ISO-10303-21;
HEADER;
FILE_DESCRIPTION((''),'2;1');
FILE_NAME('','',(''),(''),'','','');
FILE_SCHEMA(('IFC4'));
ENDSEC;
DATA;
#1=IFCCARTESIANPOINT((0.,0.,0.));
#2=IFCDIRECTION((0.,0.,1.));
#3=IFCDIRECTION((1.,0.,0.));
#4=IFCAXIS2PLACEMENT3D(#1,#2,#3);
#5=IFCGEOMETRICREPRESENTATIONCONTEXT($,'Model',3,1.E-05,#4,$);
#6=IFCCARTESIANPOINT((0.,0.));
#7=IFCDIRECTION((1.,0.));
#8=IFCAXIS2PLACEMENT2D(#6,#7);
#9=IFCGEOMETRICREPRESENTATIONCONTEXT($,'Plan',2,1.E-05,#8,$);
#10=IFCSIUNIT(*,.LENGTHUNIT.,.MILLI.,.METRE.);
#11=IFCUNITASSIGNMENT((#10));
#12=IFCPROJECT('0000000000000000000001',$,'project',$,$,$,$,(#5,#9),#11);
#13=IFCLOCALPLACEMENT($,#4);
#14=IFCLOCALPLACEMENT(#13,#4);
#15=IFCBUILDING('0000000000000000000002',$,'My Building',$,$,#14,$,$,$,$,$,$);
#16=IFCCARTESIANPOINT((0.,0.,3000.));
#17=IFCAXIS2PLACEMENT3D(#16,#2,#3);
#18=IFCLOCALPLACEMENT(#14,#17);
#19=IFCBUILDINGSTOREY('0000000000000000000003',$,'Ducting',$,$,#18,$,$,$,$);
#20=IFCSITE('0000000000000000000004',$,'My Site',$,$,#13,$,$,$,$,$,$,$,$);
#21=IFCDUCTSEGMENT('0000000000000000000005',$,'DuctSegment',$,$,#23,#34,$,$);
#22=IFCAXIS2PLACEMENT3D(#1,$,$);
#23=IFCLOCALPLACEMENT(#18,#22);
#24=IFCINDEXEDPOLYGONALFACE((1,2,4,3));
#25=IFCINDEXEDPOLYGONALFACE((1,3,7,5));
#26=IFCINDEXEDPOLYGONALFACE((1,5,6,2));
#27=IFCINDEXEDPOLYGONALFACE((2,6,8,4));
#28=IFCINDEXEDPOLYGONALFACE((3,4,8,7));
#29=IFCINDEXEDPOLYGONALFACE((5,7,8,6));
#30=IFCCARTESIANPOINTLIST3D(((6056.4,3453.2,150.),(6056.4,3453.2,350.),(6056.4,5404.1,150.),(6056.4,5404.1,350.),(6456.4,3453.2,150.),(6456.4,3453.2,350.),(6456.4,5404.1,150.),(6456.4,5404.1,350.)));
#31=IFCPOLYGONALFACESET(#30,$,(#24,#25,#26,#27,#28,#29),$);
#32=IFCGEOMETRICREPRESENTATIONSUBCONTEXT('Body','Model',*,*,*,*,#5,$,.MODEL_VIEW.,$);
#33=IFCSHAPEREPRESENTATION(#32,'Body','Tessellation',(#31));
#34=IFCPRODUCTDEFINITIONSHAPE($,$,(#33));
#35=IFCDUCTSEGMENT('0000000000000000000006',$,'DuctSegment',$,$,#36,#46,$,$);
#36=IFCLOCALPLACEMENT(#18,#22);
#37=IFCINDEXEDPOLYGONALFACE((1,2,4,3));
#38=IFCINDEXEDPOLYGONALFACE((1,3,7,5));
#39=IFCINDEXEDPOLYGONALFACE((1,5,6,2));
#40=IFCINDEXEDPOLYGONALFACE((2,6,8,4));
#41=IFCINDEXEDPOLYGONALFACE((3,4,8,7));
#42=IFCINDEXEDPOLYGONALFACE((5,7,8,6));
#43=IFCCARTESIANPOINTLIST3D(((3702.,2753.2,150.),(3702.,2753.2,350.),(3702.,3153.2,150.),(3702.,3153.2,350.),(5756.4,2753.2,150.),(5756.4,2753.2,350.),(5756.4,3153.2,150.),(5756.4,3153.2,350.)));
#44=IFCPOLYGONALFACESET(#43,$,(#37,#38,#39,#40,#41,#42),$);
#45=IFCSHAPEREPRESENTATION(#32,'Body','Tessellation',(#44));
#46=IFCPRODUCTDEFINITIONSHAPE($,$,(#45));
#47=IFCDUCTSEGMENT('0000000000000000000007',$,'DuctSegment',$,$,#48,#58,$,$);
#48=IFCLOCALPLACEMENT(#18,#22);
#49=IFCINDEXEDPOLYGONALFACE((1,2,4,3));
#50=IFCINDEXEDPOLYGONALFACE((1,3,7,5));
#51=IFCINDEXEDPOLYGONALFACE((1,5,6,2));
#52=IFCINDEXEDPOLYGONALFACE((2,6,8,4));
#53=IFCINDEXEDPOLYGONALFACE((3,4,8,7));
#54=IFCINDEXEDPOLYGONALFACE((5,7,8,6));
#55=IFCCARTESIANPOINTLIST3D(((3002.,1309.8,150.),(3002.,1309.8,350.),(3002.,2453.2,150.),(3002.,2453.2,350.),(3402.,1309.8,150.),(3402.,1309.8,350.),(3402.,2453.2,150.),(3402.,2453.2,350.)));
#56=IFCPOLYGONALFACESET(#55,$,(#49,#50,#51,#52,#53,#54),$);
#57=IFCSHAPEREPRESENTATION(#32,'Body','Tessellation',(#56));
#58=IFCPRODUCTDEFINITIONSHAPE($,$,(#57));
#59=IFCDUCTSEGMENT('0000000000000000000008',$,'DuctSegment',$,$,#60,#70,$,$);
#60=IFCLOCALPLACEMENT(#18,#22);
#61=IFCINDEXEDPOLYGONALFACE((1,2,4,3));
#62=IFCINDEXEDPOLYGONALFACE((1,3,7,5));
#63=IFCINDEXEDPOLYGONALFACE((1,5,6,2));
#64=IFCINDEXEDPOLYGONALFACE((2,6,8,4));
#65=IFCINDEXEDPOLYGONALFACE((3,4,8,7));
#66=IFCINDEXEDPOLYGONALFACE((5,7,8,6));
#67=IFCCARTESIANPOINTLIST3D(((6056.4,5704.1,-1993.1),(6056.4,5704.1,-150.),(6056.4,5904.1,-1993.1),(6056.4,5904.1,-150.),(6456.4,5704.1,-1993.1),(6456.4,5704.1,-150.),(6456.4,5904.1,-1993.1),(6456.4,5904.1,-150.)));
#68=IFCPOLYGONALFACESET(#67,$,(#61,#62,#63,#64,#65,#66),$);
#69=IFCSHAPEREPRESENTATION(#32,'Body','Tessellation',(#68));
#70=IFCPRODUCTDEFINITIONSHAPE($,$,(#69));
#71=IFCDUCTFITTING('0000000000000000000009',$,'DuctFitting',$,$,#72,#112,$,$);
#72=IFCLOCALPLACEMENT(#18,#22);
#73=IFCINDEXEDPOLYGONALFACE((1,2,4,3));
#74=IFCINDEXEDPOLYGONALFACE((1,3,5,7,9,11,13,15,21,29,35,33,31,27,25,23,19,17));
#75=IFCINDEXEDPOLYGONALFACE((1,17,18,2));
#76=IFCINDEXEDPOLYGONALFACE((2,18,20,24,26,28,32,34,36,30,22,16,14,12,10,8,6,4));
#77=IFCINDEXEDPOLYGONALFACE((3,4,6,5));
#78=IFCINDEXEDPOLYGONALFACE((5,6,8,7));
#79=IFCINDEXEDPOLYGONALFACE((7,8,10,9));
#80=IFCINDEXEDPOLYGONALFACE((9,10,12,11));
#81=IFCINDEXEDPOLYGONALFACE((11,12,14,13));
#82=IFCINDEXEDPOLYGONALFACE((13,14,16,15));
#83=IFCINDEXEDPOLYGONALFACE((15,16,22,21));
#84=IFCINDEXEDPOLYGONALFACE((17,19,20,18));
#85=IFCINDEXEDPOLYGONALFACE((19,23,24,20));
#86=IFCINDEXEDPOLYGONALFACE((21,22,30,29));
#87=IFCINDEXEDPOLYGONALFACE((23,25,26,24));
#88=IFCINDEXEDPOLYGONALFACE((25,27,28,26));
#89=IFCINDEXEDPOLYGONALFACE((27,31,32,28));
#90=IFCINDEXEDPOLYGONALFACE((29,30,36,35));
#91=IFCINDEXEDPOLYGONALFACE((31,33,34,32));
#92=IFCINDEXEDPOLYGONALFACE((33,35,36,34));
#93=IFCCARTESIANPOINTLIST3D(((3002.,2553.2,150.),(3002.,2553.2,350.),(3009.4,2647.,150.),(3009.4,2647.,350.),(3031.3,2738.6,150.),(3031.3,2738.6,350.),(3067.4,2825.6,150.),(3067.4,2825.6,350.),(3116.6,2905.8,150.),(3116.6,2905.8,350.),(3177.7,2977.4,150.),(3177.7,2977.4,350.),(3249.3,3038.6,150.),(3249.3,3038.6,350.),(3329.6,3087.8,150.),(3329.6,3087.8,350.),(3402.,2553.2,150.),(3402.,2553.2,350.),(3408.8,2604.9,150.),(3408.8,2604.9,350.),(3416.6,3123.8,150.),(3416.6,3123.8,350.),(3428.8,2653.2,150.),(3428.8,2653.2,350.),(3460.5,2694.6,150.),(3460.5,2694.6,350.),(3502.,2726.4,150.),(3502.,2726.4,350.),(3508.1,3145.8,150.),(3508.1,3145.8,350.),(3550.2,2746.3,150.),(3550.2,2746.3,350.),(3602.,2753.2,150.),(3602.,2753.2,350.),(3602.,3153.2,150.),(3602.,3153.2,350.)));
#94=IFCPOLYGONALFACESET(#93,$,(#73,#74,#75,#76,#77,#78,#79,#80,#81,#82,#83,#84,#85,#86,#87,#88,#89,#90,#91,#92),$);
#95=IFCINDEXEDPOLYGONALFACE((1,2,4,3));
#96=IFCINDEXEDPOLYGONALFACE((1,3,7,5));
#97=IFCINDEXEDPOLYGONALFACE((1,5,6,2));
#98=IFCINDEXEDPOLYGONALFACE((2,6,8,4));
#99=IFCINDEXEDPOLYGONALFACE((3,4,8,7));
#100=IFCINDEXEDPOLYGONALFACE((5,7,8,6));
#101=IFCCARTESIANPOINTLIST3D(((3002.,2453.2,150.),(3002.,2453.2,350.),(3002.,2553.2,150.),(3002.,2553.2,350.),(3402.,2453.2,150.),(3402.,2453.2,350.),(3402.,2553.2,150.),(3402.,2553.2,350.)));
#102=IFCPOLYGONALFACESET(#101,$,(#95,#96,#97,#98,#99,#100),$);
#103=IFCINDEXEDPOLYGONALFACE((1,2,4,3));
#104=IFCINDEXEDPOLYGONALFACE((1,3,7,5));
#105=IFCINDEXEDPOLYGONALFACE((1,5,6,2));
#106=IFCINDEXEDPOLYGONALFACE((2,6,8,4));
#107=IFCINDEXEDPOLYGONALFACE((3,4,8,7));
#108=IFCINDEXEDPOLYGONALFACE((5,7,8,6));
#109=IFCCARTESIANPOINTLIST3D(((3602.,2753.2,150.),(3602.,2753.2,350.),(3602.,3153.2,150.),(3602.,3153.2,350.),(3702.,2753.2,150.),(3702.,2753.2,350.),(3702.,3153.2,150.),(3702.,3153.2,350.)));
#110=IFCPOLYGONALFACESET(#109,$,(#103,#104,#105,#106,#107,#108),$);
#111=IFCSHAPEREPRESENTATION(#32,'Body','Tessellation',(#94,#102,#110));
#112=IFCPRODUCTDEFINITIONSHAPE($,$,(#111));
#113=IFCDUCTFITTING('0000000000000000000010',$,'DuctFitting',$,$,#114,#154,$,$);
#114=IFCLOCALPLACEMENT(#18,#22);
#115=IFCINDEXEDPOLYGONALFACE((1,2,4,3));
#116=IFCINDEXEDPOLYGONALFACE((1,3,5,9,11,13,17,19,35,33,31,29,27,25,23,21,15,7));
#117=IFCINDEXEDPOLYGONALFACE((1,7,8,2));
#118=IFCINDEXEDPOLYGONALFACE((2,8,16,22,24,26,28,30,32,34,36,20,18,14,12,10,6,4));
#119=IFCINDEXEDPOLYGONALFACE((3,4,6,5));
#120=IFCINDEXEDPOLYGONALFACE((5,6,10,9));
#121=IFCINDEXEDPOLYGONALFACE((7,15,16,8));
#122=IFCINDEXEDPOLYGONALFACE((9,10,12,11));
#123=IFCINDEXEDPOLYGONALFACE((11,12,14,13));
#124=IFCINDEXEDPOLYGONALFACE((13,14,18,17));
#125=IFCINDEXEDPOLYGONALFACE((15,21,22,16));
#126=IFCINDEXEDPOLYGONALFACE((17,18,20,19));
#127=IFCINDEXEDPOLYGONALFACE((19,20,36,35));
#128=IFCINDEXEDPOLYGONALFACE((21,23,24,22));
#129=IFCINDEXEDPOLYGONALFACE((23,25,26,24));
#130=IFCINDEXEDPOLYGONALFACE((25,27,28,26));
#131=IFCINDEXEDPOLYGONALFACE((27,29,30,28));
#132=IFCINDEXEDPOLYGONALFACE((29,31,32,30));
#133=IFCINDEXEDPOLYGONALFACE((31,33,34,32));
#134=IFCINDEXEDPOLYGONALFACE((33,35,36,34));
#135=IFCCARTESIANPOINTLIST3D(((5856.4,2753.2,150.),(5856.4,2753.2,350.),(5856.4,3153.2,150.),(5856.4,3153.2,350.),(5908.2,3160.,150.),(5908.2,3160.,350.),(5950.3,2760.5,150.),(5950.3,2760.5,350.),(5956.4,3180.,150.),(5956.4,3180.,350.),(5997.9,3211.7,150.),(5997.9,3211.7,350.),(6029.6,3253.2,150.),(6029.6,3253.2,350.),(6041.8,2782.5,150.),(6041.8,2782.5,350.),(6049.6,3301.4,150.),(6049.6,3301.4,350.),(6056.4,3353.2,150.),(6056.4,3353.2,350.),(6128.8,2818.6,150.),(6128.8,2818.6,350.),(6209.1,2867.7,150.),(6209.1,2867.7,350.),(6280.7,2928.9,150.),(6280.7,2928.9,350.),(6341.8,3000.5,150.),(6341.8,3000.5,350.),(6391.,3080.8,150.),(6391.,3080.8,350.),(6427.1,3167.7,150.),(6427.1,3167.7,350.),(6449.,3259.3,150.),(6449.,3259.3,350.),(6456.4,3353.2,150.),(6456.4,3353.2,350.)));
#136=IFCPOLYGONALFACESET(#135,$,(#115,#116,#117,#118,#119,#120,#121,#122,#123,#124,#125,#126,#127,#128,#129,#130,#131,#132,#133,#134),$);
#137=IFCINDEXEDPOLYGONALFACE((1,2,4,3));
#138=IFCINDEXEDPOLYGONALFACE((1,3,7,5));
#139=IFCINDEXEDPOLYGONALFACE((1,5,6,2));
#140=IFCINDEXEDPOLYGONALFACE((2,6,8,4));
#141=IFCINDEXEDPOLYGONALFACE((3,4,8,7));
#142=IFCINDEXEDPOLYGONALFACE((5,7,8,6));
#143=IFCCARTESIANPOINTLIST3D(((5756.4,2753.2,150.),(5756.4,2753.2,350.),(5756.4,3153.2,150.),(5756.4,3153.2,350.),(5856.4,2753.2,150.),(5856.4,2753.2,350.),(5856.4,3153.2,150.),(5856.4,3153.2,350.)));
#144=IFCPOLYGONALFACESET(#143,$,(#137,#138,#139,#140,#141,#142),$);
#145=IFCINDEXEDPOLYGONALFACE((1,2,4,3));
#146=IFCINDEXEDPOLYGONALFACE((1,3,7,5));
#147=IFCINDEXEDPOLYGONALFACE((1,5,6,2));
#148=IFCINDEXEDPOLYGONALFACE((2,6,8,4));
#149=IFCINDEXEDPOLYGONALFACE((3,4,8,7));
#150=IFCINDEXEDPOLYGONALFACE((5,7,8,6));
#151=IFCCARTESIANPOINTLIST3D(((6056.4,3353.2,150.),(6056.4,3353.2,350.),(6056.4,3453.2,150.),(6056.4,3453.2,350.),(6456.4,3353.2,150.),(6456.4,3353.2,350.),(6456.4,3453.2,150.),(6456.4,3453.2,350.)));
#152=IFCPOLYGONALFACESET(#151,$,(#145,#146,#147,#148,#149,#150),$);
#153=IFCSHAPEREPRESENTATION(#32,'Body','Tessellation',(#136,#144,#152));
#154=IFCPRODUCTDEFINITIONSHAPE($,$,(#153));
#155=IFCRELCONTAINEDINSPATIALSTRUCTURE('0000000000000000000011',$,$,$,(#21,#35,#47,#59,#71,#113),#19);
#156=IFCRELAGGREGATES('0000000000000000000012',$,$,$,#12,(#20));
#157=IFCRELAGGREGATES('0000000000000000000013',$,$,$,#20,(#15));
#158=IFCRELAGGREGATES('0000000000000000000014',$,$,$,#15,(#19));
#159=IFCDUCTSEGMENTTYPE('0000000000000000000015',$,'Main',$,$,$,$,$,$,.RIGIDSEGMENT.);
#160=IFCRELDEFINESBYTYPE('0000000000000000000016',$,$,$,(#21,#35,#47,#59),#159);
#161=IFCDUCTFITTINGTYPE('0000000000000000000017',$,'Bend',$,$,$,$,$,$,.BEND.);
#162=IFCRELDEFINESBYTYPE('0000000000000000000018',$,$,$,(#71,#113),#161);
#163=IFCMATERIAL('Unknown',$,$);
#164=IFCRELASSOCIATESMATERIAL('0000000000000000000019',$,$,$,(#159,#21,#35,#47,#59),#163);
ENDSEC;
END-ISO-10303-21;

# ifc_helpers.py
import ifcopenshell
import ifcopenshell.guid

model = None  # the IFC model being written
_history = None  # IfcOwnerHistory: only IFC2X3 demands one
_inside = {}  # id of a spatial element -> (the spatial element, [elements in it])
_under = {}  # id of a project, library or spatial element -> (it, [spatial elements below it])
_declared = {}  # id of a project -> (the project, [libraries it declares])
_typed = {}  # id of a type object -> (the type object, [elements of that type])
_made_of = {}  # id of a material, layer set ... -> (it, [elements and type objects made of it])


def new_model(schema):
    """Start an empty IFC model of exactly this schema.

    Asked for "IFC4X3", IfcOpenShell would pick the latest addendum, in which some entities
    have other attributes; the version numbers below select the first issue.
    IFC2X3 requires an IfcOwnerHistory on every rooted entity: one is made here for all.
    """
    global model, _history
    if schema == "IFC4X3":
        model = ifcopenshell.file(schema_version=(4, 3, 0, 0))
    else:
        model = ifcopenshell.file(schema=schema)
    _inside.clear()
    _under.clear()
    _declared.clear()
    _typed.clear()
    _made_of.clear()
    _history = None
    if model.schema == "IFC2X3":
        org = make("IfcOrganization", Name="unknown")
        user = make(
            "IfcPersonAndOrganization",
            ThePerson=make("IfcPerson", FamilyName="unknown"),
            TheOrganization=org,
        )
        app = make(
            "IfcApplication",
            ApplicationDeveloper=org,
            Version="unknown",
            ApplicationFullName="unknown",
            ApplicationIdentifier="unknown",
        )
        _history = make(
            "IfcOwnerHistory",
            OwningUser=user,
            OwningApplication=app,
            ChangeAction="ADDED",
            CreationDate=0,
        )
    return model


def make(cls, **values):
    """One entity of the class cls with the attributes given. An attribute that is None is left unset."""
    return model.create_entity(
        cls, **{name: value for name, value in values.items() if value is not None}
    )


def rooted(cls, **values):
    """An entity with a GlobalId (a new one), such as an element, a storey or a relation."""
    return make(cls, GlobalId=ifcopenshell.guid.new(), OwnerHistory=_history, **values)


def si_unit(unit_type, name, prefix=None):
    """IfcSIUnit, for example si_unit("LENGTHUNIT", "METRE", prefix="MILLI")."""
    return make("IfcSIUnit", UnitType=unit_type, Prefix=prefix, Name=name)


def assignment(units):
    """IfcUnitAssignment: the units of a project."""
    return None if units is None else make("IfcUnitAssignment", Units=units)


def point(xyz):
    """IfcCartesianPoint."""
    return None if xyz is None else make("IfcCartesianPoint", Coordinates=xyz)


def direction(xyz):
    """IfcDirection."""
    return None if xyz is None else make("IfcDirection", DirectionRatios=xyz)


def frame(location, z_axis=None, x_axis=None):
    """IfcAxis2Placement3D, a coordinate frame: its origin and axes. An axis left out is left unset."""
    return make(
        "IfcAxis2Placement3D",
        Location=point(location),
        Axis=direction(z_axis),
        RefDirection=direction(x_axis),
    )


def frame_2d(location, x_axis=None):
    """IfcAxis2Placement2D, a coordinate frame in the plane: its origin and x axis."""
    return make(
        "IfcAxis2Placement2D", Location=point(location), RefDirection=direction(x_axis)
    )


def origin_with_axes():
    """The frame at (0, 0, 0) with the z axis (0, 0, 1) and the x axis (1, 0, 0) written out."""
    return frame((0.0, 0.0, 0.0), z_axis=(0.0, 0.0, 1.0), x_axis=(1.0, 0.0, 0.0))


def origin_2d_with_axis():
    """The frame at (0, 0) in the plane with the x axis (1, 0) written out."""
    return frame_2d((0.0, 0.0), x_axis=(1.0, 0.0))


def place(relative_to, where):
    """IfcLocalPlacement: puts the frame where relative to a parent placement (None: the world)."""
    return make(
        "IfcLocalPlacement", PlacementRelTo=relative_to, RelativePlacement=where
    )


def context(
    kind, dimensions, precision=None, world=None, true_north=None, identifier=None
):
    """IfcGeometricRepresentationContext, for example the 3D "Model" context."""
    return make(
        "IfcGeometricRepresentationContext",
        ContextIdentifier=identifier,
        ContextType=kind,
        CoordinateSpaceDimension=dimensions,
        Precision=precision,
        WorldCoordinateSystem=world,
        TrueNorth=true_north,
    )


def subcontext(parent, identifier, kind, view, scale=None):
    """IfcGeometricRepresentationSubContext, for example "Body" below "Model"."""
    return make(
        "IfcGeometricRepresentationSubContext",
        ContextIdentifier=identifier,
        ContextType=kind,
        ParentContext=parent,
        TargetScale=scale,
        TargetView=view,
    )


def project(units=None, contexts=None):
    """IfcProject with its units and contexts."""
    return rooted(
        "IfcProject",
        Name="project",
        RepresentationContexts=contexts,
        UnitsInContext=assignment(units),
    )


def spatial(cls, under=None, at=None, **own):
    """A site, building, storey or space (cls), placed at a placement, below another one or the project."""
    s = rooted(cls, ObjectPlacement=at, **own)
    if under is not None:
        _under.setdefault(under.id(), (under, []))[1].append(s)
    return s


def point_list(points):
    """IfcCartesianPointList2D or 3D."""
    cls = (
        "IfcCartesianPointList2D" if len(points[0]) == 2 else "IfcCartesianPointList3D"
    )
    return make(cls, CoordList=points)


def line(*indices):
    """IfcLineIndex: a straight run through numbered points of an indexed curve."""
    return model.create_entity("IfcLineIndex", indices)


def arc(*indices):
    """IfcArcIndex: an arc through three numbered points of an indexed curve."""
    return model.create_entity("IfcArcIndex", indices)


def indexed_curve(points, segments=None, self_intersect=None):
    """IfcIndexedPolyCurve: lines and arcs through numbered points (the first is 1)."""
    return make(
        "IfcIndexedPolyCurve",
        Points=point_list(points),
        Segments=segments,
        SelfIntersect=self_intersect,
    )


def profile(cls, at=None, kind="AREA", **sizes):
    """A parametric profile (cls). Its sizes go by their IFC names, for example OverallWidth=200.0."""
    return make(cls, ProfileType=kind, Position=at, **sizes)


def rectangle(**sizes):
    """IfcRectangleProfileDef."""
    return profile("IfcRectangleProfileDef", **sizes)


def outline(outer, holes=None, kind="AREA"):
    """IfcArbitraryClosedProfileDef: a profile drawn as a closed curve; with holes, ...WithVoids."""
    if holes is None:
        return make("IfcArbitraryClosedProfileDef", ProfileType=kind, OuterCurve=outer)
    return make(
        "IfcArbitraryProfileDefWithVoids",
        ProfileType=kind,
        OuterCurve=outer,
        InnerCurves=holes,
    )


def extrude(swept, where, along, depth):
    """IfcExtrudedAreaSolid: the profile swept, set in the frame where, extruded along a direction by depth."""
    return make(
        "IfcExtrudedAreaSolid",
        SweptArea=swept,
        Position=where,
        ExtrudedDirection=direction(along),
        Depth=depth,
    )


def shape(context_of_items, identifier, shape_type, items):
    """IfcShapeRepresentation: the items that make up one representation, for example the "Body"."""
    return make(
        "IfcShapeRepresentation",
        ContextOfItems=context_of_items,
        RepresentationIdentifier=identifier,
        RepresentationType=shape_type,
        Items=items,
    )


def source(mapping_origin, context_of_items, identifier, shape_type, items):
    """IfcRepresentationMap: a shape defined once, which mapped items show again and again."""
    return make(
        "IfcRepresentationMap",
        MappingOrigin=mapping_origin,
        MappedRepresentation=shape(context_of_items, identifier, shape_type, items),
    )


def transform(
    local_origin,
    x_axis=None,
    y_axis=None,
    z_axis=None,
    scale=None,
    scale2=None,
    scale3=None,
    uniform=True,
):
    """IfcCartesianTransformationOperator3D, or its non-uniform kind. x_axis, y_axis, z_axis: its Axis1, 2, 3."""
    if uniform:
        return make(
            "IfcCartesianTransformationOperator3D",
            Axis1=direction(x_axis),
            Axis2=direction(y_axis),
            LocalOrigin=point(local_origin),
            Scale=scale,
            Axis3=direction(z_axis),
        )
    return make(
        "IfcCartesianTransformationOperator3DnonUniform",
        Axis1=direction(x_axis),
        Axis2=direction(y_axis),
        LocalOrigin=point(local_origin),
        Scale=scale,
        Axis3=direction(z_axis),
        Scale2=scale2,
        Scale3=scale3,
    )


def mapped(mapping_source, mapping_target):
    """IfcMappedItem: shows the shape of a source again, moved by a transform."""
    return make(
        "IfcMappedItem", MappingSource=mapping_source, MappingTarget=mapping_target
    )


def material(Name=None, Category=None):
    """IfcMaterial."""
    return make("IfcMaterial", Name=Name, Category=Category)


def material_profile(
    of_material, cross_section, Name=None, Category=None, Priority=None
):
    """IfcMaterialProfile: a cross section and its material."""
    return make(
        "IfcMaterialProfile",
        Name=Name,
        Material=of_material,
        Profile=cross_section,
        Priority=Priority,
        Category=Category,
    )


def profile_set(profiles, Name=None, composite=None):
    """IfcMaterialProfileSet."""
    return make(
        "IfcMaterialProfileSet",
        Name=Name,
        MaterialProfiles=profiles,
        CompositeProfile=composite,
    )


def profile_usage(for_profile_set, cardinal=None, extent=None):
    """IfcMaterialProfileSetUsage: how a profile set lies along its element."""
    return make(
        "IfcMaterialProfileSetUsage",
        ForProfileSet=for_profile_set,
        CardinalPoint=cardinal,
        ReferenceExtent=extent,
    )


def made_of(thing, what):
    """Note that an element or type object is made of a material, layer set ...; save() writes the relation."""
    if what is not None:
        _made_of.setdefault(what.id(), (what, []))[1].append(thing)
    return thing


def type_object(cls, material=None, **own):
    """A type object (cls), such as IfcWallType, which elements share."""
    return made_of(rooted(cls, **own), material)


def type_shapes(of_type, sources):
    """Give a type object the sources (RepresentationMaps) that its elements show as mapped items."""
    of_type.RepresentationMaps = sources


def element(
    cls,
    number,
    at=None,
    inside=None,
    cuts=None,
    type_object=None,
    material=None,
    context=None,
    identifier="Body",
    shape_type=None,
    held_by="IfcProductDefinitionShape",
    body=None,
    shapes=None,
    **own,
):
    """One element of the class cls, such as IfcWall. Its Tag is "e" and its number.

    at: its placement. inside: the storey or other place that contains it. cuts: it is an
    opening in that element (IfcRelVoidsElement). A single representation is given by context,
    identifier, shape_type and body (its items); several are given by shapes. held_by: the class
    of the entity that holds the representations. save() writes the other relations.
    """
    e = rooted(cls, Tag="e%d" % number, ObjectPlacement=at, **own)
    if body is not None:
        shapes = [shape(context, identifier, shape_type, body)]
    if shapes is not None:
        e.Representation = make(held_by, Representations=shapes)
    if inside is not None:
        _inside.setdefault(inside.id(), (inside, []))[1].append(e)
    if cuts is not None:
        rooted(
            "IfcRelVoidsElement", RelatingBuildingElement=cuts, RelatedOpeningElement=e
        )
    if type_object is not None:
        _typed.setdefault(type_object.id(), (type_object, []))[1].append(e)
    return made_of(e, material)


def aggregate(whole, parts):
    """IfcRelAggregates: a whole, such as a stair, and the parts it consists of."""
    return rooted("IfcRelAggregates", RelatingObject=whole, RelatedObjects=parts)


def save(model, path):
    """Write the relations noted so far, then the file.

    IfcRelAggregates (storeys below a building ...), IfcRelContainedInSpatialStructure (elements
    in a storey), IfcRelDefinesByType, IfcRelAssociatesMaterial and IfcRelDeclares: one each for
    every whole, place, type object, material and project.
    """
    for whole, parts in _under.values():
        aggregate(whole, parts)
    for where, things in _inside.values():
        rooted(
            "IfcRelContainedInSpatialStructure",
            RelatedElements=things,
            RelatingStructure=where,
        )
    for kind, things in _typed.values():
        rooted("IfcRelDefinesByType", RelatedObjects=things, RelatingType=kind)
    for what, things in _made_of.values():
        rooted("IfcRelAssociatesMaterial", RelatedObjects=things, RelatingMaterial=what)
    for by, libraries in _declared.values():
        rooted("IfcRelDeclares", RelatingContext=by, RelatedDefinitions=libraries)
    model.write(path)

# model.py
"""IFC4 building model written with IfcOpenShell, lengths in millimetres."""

from ifc_helpers import new_model, si_unit, frame, origin_with_axes, origin_2d_with_axis, place, context, subcontext, project, spatial, line, arc, indexed_curve, rectangle, outline, extrude, source, transform, mapped, material, material_profile, profile_set, profile_usage, type_object, type_shapes, element, save


model = new_model("IFC4")

# Units and contexts
model_context = context("Model", 3, precision=1e-05, world=origin_with_axes())
plan_context = context("Plan", 2, precision=1e-05, world=origin_2d_with_axis())
body_context = subcontext(model_context, "Body", "Model", "MODEL_VIEW")
ifc_project = project(units=[si_unit("LENGTHUNIT", "METRE", prefix="MILLI")], contexts=[model_context, plan_context])

# Site, building, storey
site_placement = place(None, origin_with_axes())
site = spatial("IfcSite", under=ifc_project, at=site_placement, Name="My Site")
building_placement = place(site_placement, origin_with_axes())
building = spatial("IfcBuilding", under=site, at=building_placement, Name="My Building")
storey_placement = place(building_placement, frame((0.0, 0.0, 3000.0), z_axis=(0.0, 0.0, 1.0), x_axis=(1.0, 0.0, 0.0)))
storey = spatial("IfcBuildingStorey", under=building, at=storey_placement, Name="Ducting")

# Duct segments
ifc_material = material(Name="Unknown")
ifc_material_profile = material_profile(ifc_material, rectangle(XDim=400.0, YDim=200.0))
ifc_profile_set = profile_set([ifc_material_profile])
ifc_profile_usage_1 = profile_usage(ifc_profile_set, cardinal=5)
duct_segment_type = type_object("IfcDuctSegmentType", Name="Main", PredefinedType="RIGIDSEGMENT", material=ifc_profile_set)
duct_segment_1_placement = place(storey_placement, frame((6256.4, 3453.2, 250.0), z_axis=(0.0, 1.0, 0.0), x_axis=(-1.0, 0.0, 0.0)))
element("IfcDuctSegment", 1, at=duct_segment_1_placement, inside=storey, type_object=duct_segment_type, material=ifc_profile_usage_1, Name="DuctSegment", context=body_context, shape_type="SweptSolid", body=[
    extrude(rectangle(XDim=400.0, YDim=200.0), origin_with_axes(), (0.0, 0.0, 1.0), 1950.9),
])
ifc_profile_usage_2 = profile_usage(ifc_profile_set, cardinal=5)
duct_segment_2_placement = place(storey_placement, frame((5756.4, 2953.2, 250.0), z_axis=(-1.0, 0.0, 0.0), x_axis=(0.0, -1.0, 0.0)))
element("IfcDuctSegment", 2, at=duct_segment_2_placement, inside=storey, type_object=duct_segment_type, material=ifc_profile_usage_2, Name="DuctSegment", context=body_context, shape_type="SweptSolid", body=[
    extrude(rectangle(XDim=400.0, YDim=200.0), origin_with_axes(), (0.0, 0.0, 1.0), 2054.5),
])
ifc_profile_usage_3 = profile_usage(ifc_profile_set, cardinal=5)
duct_segment_3_placement = place(storey_placement, frame((3202.0, 1309.8, 250.0), z_axis=(0.0, 1.0, 0.0), x_axis=(-1.0, 0.0, 0.0)))
element("IfcDuctSegment", 3, at=duct_segment_3_placement, inside=storey, type_object=duct_segment_type, material=ifc_profile_usage_3, Name="DuctSegment", context=body_context, shape_type="SweptSolid", body=[
    extrude(rectangle(XDim=400.0, YDim=200.0), origin_with_axes(), (0.0, 0.0, 1.0), 1143.4),
])
ifc_profile_usage_4 = profile_usage(ifc_profile_set, cardinal=5)
duct_segment_4_placement = place(storey_placement, frame((6256.4, 5804.1, -150.0), z_axis=(0.0, 0.0, -1.0), x_axis=(-1.0, 0.0, 0.0)))
element("IfcDuctSegment", 4, at=duct_segment_4_placement, inside=storey, type_object=duct_segment_type, material=ifc_profile_usage_4, Name="DuctSegment", context=body_context, shape_type="SweptSolid", body=[
    extrude(rectangle(XDim=400.0, YDim=200.0), origin_with_axes(), (0.0, 0.0, 1.0), 1843.1),
])

# Duct fittings
duct_fitting_type = type_object("IfcDuctFittingType", Name="Bend", PredefinedType="BEND")
shared_shape = source(origin_with_axes(), body_context, "Body", "SweptSolid", [
    extrude(outline(indexed_curve([(-200.0, 0.0), (-258.6, 141.4), (-400.0, 200.0), (-400.0, 600.0), (24.3, 424.3), (200.0, 0.0)], segments=[arc(1, 2, 3), line(3, 4), arc(4, 5, 6), line(6, 1)])), frame((0.0, -100.0, 100.0), z_axis=(0.0, -1.0, 0.0), x_axis=(1.0, 0.0, 0.0)), (0.0, 0.0, -1.0), 200.0),
    extrude(rectangle(XDim=400.0, YDim=200.0), origin_with_axes(), (0.0, 0.0, 1.0), 100.0),
    extrude(rectangle(XDim=400.0, YDim=200.0), frame((-400.0, 0.0, 500.0), z_axis=(-1.0, 0.0, 0.0), x_axis=(0.0, 0.0, -1.0)), (0.0, 0.0, 1.0), 100.0),
])
type_shapes(duct_fitting_type, [shared_shape])
for number, where, z_axis, x_axis, name in (
    (5, (3202.0, 2453.2, 250.0), (0.0, 1.0, 0.0), (-1.0, 0.0, 0.0), "DuctFitting"),
    (6, (5756.4, 2953.2, 250.0), (1.0, 0.0, 0.0), (0.0, -1.0, 0.0), "DuctFitting"),
):
    element("IfcDuctFitting", number, at=place(storey_placement, frame(where, z_axis=z_axis, x_axis=x_axis)), inside=storey, type_object=duct_fitting_type, Name=name, context=body_context, shape_type="MappedRepresentation", body=[
        mapped(shared_shape, transform((0.0, 0.0, 0.0), x_axis=(1.0, 0.0, 0.0), y_axis=(0.0, 1.0, 0.0), z_axis=(0.0, 0.0, 1.0), scale=1.0)),
    ])

save(model, "model.ifc")
